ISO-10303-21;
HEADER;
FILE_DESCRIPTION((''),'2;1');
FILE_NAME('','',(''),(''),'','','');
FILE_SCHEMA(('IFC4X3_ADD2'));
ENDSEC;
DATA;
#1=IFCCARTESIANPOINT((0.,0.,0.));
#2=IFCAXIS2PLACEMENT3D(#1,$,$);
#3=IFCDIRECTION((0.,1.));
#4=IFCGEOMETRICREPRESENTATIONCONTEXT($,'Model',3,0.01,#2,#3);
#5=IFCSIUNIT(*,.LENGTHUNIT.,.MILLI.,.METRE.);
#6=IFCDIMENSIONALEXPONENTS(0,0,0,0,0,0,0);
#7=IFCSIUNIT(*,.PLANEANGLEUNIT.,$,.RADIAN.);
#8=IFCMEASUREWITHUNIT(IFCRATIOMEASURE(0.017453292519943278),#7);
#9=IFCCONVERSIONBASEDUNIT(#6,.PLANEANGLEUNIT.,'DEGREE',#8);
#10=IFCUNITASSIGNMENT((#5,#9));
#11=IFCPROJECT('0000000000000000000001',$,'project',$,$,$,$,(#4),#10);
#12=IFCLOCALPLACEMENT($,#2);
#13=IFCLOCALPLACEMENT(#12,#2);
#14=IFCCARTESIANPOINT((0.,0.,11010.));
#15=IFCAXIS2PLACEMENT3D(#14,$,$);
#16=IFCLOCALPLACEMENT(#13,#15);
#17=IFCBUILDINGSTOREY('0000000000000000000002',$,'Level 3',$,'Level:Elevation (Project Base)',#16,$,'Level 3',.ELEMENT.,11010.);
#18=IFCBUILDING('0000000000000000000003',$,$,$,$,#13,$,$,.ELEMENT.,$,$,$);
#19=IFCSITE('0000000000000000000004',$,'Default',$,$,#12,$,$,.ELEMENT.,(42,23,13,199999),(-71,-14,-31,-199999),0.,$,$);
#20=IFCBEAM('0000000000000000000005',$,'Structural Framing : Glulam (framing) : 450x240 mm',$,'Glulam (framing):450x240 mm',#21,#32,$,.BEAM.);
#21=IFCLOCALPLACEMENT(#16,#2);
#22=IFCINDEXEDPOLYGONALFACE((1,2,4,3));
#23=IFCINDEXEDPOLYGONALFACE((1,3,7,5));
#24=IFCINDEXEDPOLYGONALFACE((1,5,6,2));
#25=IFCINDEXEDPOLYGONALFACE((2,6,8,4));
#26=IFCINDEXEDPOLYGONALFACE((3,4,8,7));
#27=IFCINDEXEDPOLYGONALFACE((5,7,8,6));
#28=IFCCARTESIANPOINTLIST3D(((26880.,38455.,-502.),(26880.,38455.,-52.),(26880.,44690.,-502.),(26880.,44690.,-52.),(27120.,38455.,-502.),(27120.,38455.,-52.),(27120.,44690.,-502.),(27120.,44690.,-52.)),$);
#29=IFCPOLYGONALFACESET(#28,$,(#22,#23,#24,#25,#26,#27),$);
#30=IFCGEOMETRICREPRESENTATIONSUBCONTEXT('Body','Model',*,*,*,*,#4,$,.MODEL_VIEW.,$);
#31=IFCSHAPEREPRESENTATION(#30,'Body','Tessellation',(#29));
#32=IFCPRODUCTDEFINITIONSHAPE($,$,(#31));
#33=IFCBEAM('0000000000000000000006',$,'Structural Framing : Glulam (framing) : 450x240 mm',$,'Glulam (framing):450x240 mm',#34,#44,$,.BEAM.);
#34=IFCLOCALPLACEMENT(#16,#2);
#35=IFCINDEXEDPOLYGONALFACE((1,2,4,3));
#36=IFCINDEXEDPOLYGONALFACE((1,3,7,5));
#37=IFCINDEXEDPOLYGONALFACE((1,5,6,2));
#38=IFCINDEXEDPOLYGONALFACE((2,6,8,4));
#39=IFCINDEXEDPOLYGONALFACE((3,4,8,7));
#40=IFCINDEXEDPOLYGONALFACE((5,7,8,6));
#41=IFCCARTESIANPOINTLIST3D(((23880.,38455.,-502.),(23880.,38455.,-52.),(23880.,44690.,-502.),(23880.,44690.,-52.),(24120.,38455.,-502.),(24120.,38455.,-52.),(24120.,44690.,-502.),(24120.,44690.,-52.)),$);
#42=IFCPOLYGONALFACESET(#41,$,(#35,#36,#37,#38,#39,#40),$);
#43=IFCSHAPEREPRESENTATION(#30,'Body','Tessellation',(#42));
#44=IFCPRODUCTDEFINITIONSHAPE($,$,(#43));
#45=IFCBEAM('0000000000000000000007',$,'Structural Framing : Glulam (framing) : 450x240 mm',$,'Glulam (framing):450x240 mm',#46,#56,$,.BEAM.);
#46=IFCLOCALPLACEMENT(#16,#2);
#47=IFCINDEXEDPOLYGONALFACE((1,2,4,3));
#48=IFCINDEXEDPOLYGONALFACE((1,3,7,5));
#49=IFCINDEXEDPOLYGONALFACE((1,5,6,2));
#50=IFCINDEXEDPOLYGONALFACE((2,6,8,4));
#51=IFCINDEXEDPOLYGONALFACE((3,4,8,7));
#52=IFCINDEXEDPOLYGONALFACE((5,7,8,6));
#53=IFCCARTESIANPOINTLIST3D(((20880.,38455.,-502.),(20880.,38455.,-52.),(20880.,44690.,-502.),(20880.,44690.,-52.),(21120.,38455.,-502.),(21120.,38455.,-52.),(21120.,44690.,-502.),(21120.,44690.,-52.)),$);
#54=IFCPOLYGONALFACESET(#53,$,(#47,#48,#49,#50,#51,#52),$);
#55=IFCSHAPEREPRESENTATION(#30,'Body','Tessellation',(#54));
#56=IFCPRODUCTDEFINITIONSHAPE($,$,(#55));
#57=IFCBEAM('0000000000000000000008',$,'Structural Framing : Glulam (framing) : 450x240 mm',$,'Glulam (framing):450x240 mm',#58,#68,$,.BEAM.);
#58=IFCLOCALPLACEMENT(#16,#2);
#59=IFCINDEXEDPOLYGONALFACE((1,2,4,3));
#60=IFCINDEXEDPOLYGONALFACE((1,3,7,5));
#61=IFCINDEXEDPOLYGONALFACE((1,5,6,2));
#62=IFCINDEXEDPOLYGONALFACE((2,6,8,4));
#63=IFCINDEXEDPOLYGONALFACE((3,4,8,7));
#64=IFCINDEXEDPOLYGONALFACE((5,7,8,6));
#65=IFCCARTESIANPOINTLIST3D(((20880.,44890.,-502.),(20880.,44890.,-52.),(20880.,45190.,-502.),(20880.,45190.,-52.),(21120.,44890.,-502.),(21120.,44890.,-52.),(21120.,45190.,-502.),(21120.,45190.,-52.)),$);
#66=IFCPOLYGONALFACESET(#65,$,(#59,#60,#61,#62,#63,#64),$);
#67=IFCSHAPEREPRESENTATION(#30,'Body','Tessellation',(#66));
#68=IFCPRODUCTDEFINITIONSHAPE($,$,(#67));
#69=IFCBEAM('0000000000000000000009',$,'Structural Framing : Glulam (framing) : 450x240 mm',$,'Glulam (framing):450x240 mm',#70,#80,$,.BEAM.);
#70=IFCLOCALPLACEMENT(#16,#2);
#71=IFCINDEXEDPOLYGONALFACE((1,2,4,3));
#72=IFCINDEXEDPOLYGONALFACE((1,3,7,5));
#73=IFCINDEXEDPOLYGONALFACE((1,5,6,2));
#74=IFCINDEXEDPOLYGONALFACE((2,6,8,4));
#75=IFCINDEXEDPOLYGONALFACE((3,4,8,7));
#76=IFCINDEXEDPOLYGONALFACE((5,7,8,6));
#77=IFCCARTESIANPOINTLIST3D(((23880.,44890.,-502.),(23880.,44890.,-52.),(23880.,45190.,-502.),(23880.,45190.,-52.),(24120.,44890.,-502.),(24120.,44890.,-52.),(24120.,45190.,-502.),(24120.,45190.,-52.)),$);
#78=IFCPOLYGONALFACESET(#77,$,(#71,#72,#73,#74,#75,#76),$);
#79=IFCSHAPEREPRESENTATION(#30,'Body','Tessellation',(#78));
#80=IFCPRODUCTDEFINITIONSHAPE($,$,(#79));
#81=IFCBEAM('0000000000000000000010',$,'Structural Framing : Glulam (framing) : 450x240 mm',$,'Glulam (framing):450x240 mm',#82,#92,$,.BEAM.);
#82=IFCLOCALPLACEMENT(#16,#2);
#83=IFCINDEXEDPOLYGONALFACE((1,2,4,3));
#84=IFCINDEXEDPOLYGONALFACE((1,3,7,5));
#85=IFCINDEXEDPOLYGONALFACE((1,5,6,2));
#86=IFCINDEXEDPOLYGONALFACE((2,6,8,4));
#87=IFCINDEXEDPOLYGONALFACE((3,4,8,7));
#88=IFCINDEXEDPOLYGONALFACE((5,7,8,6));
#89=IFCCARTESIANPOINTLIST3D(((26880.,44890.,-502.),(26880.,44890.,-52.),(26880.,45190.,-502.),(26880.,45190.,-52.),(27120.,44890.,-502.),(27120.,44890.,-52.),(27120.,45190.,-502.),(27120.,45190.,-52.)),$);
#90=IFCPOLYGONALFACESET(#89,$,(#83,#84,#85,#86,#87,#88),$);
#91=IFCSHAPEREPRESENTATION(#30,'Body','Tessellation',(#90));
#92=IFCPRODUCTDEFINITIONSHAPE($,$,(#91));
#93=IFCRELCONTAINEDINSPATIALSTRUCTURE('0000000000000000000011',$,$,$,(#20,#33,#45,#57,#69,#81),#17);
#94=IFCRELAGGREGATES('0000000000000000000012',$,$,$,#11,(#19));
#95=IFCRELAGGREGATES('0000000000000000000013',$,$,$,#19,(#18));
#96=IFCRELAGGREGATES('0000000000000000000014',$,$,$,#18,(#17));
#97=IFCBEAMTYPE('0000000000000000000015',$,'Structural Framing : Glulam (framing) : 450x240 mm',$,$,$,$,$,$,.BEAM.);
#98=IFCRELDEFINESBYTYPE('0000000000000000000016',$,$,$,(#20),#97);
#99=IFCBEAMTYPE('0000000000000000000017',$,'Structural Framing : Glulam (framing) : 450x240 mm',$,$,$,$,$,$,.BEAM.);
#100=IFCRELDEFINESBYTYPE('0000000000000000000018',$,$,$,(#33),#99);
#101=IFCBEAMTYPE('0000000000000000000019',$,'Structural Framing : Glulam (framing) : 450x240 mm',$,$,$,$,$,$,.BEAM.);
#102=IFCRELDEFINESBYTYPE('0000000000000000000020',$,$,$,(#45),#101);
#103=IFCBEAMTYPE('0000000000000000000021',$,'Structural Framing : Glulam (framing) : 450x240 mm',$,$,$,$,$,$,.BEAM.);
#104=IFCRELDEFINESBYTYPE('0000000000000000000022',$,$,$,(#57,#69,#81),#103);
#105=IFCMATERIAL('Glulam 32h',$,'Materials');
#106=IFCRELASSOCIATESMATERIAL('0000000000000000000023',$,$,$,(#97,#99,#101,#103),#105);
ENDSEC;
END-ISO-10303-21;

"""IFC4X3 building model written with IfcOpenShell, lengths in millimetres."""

from ifc_helpers import new_model, entity, si_unit, converted_unit, direction, frame, origin, origin_2d_with_axis, place, context, subcontext, project, spatial, rectangle, extrude, source, transform, mapped, material, material_profile, profile_set, type_object, type_shapes, element, save


model = new_model("IFC4X3")

# Units and contexts
model_context = context("Model", 3, precision=0.01, world=origin(), true_north=direction((0.0, 1.0)))
body_context = subcontext(model_context, "Body", "Model", "MODEL_VIEW")
ifc_project = project(units=[si_unit("LENGTHUNIT", "METRE", prefix="MILLI"), converted_unit("PLANEANGLEUNIT", "DEGREE", entity("IfcRatioMeasure", 0.017453292519943278), si_unit("PLANEANGLEUNIT", "RADIAN"), dimensions=[0, 0, 0, 0, 0, 0, 0])], contexts=[model_context])

# Site, building, storey
site_placement = place(None, origin())
site = spatial("IfcSite", under=ifc_project, at=site_placement, Name="Default", CompositionType="ELEMENT", RefLatitude=(42, 23, 13, 199999), RefLongitude=(-71, -14, -31, -199999), RefElevation=0.0)
building_placement = place(site_placement, origin())
building = spatial("IfcBuilding", under=site, at=building_placement, CompositionType="ELEMENT")
storey_placement = place(building_placement, frame((0.0, 0.0, 11010.0)))
storey = spatial("IfcBuildingStorey", under=building, at=storey_placement, Name="Level 3", ObjectType="Level:Elevation (Project Base)", LongName="Level 3", CompositionType="ELEMENT", Elevation=11010.0)

# Beams
ifc_material_1 = material(Name="Glulam 32h", Category="Materials")
ifc_material_profile_1 = material_profile(ifc_material_1, rectangle(XDim=450.0, YDim=240.0, at=origin_2d_with_axis()), Name="450x240 mm")
ifc_profile_set_1 = profile_set([ifc_material_profile_1], Name="450x240 mm")
beam_type_1 = type_object("IfcBeamType", Name="Structural Framing : Glulam (framing) : 450x240 mm", PredefinedType="BEAM", material=ifc_profile_set_1)
shared_shape_1 = source(origin(), body_context, "Body", "SweptSolid", [
    extrude(rectangle(XDim=450.0, YDim=240.0, at=origin_2d_with_axis()), frame((-2910.0, 0.0, 0.0), z_axis=(1.0, 0.0, 0.0), x_axis=(0.0, 0.0, -1.0)), (0.0, 0.0, 1.0), 6235.0),
])
type_shapes(beam_type_1, [shared_shape_1])
beam_1_placement = place(storey_placement, frame((27000.0, 41780.0, -277.0), z_axis=(0.0, 0.0, 1.0), x_axis=(0.0, -1.0, 0.0)))
element("IfcBeam", 1, at=beam_1_placement, inside=storey, type_object=beam_type_1, Name="Structural Framing : Glulam (framing) : 450x240 mm", ObjectType="Glulam (framing):450x240 mm", PredefinedType="BEAM", context=body_context, shape_type="MappedRepresentation", body=[
    mapped(shared_shape_1, transform((0.0, 0.0, 0.0), scale=1.0)),
])
beam_type_2 = type_object("IfcBeamType", Name="Structural Framing : Glulam (framing) : 450x240 mm", PredefinedType="BEAM", material=ifc_profile_set_1)
shared_shape_2 = source(origin(), body_context, "Body", "SweptSolid", [
    extrude(rectangle(XDim=450.0, YDim=240.0, at=origin_2d_with_axis()), frame((-2940.0, 0.0, 0.0), z_axis=(1.0, 0.0, 0.0), x_axis=(0.0, 0.0, -1.0)), (0.0, 0.0, 1.0), 6235.0),
])
type_shapes(beam_type_2, [shared_shape_2])
beam_2_placement = place(storey_placement, frame((24000.0, 41750.0, -277.0), z_axis=(0.0, 0.0, 1.0), x_axis=(0.0, -1.0, 0.0)))
element("IfcBeam", 2, at=beam_2_placement, inside=storey, type_object=beam_type_2, Name="Structural Framing : Glulam (framing) : 450x240 mm", ObjectType="Glulam (framing):450x240 mm", PredefinedType="BEAM", context=body_context, shape_type="MappedRepresentation", body=[
    mapped(shared_shape_2, transform((0.0, 0.0, 0.0), scale=1.0)),
])
beam_type_3 = type_object("IfcBeamType", Name="Structural Framing : Glulam (framing) : 450x240 mm", PredefinedType="BEAM", material=ifc_profile_set_1)
shared_shape_3 = source(origin(), body_context, "Body", "SweptSolid", [
    extrude(rectangle(XDim=450.0, YDim=240.0, at=origin_2d_with_axis()), frame((-2860.0, 0.0, 0.0), z_axis=(1.0, 0.0, 0.0), x_axis=(0.0, 0.0, -1.0)), (0.0, 0.0, 1.0), 6235.0),
])
type_shapes(beam_type_3, [shared_shape_3])
beam_3_placement = place(storey_placement, frame((21000.0, 41830.0, -277.0), z_axis=(0.0, 0.0, 1.0), x_axis=(0.0, -1.0, 0.0)))
element("IfcBeam", 3, at=beam_3_placement, inside=storey, type_object=beam_type_3, Name="Structural Framing : Glulam (framing) : 450x240 mm", ObjectType="Glulam (framing):450x240 mm", PredefinedType="BEAM", context=body_context, shape_type="MappedRepresentation", body=[
    mapped(shared_shape_3, transform((0.0, 0.0, 0.0), scale=1.0)),
])
beam_type_4 = type_object("IfcBeamType", Name="Structural Framing : Glulam (framing) : 450x240 mm", PredefinedType="BEAM", material=ifc_profile_set_1)
shared_shape_4 = source(origin(), body_context, "Body", "SweptSolid", [
    extrude(rectangle(XDim=450.0, YDim=240.0, at=origin_2d_with_axis()), frame((5043.7, 0.0, 0.0), z_axis=(1.0, 0.0, 0.0), x_axis=(0.0, 0.0, -1.0)), (0.0, 0.0, 1.0), 300.0),
])
type_shapes(beam_type_4, [shared_shape_4])
for number, where, z_axis, x_axis, name in (
    (4, (21000.0, 50233.7, -277.0), (0.0, 0.0, 1.0), (0.0, -1.0, 0.0), "Structural Framing : Glulam (framing) : 450x240 mm"),
    (5, (24000.0, 50233.7, -277.0), (0.0, 0.0, 1.0), (0.0, -1.0, 0.0), "Structural Framing : Glulam (framing) : 450x240 mm"),
    (6, (27000.0, 50233.7, -277.0), (0.0, 0.0, 1.0), (0.0, -1.0, 0.0), "Structural Framing : Glulam (framing) : 450x240 mm"),
):
    element("IfcBeam", number, at=place(storey_placement, frame(where, z_axis=z_axis, x_axis=x_axis)), inside=storey, type_object=beam_type_4, Name=name, ObjectType="Glulam (framing):450x240 mm", PredefinedType="BEAM", context=body_context, shape_type="MappedRepresentation", body=[
        mapped(shared_shape_4, transform((0.0, 0.0, 0.0), scale=1.0)),
    ])

save(model, "model.ifc")
